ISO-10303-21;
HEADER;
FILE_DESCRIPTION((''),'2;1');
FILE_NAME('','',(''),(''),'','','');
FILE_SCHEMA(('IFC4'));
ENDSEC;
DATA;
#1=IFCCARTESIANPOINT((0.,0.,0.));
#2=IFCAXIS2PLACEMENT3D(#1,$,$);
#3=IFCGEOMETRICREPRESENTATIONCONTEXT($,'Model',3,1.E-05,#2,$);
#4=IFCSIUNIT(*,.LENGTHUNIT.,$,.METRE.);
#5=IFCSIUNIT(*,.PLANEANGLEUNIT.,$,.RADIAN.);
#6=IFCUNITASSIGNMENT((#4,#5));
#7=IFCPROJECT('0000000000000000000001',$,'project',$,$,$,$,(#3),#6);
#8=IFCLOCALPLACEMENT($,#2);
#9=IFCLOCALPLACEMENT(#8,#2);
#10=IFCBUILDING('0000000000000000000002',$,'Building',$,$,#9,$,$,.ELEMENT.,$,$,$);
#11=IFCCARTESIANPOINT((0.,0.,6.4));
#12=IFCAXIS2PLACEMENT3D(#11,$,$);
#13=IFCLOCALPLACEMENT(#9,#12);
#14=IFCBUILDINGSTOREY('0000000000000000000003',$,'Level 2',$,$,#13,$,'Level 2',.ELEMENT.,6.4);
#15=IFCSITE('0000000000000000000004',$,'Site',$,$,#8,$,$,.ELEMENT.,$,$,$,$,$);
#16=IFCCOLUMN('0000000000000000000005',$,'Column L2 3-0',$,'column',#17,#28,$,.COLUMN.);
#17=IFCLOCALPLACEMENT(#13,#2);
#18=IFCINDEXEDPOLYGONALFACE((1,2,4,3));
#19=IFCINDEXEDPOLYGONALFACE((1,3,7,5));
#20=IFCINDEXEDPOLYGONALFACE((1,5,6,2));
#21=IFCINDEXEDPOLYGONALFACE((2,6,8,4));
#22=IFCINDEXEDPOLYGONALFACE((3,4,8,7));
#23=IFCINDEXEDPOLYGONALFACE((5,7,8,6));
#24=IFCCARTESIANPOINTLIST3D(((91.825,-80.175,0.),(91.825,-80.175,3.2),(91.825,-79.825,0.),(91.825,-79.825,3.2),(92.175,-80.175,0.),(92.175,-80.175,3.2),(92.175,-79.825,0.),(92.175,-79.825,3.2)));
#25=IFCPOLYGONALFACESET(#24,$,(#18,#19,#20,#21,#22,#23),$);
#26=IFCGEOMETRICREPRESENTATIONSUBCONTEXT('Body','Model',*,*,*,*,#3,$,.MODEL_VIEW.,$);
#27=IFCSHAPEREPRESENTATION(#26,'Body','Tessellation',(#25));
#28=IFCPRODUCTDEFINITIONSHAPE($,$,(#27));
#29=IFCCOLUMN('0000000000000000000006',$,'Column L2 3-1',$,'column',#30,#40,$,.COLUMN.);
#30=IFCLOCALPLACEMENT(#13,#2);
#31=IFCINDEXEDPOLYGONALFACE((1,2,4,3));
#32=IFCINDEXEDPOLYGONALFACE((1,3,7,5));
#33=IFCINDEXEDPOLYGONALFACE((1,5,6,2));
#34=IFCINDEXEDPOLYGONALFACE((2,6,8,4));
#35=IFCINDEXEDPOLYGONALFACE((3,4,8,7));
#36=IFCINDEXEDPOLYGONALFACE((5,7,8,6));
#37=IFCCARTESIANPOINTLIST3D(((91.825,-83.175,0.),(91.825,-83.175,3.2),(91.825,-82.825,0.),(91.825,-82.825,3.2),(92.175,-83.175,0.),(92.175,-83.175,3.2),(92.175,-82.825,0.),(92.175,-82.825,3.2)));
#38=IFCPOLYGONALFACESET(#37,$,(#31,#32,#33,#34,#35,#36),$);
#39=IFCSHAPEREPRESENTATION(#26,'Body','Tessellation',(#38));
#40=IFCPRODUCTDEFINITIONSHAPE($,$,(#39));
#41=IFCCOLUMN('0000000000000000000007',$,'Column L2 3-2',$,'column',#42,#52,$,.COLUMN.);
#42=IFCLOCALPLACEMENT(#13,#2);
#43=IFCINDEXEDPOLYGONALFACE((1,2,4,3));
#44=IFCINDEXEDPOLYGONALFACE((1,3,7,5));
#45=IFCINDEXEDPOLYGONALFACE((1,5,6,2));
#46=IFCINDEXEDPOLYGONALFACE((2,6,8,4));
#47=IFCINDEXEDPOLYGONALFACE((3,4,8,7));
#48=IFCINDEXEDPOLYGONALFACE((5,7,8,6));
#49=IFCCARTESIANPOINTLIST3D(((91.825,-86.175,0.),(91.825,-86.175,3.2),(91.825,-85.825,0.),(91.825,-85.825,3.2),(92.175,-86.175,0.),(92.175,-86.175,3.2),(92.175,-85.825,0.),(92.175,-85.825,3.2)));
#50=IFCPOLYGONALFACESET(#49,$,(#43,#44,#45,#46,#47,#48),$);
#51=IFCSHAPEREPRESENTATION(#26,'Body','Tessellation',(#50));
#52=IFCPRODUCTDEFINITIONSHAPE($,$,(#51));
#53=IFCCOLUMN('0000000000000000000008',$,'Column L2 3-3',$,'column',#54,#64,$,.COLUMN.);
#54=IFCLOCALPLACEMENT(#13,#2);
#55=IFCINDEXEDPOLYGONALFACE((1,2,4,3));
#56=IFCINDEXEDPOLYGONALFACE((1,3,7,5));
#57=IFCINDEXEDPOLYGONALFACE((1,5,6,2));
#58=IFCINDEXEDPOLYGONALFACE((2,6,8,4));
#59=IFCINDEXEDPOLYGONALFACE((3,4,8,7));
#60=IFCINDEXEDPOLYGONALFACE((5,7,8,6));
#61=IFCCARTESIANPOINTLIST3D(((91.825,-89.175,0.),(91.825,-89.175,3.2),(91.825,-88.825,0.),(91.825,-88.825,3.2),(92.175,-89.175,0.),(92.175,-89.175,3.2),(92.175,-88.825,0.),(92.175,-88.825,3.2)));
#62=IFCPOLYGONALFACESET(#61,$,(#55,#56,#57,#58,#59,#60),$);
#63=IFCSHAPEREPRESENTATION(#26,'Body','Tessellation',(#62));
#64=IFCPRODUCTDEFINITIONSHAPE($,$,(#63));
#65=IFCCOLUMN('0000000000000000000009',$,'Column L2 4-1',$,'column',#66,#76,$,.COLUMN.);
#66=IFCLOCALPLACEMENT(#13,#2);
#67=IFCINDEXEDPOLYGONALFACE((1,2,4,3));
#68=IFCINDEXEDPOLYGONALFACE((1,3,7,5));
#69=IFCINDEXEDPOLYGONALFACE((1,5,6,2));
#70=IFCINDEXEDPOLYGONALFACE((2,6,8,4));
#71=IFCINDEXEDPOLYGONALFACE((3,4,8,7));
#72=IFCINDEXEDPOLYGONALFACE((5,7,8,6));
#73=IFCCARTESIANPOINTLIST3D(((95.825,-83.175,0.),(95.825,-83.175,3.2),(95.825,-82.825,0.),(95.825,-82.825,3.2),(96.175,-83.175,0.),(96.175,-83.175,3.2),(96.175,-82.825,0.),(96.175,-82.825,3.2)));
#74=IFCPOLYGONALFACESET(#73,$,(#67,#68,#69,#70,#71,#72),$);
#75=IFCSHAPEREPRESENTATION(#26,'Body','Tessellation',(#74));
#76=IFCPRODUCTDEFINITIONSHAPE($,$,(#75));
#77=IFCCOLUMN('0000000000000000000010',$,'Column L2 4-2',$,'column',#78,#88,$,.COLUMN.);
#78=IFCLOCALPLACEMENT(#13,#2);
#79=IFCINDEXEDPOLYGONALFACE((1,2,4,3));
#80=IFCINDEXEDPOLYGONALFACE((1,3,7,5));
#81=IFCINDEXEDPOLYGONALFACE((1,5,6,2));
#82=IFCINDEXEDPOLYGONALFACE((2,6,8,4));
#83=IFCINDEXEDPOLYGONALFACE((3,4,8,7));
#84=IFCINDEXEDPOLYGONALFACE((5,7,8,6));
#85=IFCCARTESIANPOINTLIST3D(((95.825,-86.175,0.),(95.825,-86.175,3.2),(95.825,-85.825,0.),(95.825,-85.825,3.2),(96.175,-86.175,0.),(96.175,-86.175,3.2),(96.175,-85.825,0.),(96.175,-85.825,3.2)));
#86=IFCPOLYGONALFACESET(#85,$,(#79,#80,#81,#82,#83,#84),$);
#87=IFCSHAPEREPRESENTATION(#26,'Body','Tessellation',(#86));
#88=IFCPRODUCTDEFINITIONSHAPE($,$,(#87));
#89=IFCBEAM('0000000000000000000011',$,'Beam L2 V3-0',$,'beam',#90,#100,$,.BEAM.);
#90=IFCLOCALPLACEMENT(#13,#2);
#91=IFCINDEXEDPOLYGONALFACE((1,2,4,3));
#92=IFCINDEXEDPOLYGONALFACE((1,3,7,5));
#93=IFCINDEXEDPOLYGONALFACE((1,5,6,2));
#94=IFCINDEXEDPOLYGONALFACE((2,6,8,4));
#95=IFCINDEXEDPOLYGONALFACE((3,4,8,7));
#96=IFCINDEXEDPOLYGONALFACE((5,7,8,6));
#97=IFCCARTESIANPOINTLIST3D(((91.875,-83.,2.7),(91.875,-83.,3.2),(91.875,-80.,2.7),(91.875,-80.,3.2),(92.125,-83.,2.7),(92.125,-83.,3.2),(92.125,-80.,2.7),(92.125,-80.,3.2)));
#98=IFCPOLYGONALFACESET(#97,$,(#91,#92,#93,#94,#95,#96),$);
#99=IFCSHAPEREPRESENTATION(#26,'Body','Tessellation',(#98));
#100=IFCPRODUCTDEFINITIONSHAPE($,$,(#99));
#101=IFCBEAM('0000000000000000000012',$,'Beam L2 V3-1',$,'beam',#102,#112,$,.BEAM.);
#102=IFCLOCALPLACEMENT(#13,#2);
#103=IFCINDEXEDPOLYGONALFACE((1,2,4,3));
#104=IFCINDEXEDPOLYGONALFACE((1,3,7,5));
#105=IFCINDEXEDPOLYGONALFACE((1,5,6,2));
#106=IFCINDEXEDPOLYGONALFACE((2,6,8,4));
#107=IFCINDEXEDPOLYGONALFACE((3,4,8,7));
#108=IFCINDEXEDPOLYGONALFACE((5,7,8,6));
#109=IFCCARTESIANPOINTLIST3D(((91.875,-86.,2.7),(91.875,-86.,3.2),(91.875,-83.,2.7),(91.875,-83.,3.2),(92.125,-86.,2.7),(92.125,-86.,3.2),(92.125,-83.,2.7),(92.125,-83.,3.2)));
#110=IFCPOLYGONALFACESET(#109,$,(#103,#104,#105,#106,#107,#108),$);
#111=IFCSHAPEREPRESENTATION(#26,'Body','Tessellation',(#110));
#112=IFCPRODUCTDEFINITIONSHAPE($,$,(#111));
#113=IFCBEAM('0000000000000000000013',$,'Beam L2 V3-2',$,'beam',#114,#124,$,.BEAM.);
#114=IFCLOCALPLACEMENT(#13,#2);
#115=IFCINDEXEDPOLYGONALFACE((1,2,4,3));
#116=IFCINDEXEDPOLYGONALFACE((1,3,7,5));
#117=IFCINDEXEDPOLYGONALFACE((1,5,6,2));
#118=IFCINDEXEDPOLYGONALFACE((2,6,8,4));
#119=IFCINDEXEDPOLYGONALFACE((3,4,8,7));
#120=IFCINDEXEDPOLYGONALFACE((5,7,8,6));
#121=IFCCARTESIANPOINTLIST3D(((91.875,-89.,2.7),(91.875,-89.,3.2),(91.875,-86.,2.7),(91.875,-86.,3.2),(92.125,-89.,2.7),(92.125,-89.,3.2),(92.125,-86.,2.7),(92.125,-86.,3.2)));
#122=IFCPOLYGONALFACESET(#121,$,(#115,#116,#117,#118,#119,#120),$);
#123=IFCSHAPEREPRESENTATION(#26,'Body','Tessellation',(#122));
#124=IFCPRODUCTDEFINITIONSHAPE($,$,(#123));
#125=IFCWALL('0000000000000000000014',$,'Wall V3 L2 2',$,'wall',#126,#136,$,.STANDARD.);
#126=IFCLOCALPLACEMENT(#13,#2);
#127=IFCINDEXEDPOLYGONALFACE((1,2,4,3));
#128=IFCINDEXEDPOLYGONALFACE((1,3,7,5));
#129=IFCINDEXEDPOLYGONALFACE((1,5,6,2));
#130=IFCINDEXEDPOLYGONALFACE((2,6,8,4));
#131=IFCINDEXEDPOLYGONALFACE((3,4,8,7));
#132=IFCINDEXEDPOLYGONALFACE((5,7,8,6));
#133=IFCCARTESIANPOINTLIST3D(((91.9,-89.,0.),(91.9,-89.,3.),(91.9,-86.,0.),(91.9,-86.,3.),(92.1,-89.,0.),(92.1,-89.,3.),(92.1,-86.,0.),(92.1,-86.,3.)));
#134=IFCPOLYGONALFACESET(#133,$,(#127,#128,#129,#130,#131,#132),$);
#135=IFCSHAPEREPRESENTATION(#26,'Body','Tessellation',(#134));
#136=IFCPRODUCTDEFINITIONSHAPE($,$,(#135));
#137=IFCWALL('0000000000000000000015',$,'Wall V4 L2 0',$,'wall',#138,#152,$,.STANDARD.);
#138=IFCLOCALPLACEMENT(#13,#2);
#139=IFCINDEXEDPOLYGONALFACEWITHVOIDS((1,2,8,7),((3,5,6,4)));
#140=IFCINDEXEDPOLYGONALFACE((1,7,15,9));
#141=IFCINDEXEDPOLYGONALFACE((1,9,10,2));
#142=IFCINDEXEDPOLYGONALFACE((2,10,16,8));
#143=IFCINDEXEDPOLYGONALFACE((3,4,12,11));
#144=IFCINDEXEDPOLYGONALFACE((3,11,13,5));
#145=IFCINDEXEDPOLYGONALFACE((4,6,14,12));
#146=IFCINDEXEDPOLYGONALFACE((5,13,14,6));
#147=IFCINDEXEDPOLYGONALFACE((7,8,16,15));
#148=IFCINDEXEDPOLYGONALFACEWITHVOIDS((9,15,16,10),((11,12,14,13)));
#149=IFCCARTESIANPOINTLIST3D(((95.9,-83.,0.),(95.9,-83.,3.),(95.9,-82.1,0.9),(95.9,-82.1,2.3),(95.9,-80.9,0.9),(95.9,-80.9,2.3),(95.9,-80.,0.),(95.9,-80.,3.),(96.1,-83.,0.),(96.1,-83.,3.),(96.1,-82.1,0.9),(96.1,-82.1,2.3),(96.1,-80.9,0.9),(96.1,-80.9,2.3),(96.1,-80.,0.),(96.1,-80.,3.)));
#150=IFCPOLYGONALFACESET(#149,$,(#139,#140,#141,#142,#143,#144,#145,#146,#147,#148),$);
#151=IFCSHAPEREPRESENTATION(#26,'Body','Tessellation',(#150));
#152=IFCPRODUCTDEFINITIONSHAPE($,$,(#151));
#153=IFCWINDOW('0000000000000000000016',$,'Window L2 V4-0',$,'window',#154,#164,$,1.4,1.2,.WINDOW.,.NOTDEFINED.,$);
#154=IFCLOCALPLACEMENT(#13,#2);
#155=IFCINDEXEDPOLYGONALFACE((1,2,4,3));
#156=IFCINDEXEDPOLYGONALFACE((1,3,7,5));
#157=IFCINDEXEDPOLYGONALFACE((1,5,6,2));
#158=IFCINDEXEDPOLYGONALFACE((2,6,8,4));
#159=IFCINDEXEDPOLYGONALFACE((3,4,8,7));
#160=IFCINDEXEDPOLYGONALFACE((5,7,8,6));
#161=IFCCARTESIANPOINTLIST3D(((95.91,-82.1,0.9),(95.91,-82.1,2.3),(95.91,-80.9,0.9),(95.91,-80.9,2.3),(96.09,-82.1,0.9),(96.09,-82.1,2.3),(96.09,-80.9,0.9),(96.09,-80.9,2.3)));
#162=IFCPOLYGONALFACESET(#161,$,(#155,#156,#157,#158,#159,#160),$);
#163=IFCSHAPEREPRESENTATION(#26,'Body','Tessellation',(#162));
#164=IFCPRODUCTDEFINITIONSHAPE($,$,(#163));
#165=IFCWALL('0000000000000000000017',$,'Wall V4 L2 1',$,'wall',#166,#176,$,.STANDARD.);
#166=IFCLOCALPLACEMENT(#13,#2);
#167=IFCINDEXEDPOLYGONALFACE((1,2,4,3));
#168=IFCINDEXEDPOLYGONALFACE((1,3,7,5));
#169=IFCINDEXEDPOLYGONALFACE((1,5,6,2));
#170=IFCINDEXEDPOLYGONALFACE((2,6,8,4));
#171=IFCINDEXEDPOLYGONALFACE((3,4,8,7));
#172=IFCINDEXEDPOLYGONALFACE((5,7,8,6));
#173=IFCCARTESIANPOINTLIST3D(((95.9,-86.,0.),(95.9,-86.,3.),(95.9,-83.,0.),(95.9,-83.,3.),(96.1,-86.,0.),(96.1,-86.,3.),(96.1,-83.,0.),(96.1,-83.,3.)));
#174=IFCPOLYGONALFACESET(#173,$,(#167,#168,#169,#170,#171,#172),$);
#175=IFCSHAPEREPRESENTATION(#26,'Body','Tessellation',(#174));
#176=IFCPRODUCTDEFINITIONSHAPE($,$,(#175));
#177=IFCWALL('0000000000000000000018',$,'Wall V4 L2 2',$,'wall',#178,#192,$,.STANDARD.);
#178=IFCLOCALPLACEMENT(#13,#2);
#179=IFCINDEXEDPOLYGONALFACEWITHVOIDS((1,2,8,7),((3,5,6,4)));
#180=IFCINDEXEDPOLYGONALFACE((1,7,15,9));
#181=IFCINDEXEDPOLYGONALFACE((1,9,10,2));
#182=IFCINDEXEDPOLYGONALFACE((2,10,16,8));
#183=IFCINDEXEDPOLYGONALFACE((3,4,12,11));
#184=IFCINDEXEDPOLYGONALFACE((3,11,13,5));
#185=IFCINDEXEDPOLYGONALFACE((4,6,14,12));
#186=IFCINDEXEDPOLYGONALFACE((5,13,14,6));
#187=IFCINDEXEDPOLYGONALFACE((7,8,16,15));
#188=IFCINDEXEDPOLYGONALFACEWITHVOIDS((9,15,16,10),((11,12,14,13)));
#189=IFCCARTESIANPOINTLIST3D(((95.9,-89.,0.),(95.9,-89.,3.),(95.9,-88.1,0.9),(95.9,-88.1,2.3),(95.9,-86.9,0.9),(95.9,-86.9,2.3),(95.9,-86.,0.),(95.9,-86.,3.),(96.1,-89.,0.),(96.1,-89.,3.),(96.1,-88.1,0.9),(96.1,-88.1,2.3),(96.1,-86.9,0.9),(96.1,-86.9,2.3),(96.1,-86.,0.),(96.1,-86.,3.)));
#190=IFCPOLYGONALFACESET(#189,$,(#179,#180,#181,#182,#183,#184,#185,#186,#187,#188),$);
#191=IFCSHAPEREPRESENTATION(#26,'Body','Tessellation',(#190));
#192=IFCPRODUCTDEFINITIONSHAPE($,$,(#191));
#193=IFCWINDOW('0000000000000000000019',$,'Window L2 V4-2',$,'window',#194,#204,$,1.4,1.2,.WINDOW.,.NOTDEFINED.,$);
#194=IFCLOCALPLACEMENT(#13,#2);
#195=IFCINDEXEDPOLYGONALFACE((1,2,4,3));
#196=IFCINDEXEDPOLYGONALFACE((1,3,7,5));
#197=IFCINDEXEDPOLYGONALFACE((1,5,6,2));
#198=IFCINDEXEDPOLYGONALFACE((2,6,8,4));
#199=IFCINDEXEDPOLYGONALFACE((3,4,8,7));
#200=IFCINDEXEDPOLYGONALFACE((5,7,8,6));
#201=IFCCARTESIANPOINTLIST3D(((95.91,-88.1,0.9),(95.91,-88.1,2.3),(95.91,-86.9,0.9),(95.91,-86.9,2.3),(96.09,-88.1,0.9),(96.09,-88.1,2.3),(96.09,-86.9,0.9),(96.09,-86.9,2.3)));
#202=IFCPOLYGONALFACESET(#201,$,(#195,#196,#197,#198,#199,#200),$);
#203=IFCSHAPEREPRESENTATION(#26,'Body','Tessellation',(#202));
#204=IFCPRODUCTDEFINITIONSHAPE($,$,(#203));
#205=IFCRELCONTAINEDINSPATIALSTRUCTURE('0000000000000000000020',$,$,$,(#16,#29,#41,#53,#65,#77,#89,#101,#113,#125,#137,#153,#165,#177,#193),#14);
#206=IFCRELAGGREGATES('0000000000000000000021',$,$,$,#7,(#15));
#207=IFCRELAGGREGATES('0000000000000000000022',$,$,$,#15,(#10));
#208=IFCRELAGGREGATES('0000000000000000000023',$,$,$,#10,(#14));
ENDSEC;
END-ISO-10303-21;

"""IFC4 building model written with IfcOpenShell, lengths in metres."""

from ifc_helpers import new_model, si_unit, frame, frame_2d, origin, origin_2d, place, context, subcontext, project, spatial, rectangle, extrude, element, fill, save


model = new_model("IFC4")

# Units and contexts
model_context = context("Model", 3, precision=1e-05, world=origin())
body_context = subcontext(model_context, "Body", "Model", "MODEL_VIEW")
ifc_project = project(units=[si_unit("LENGTHUNIT", "METRE"), si_unit("PLANEANGLEUNIT", "RADIAN")], contexts=[model_context])

# Site, building, storey
site_placement = place(None, origin())
site = spatial("IfcSite", under=ifc_project, at=site_placement, Name="Site", CompositionType="ELEMENT")
building_placement = place(site_placement, origin())
building = spatial("IfcBuilding", under=site, at=building_placement, Name="Building", CompositionType="ELEMENT")
storey_placement = place(building_placement, frame((0.0, 0.0, 6.4)))
storey = spatial("IfcBuildingStorey", under=building, at=storey_placement, Name="Level 2", LongName="Level 2", CompositionType="ELEMENT", Elevation=6.4)

# Columns
for number, where, name in (
    (1, (92.0, -80.0, 0.0), "Column L2 3-0"),
    (2, (92.0, -83.0, 0.0), "Column L2 3-1"),
    (3, (92.0, -86.0, 0.0), "Column L2 3-2"),
    (4, (92.0, -89.0, 0.0), "Column L2 3-3"),
    (5, (96.0, -83.0, 0.0), "Column L2 4-1"),
    (6, (96.0, -86.0, 0.0), "Column L2 4-2"),
):
    element("IfcColumn", number, at=place(storey_placement, frame(where)), inside=storey, Name=name, ObjectType="column", PredefinedType="COLUMN", context=body_context, shape_type="SweptSolid", body=[
        extrude(rectangle(XDim=0.35, YDim=0.35, at=origin_2d()), origin(), (0.0, 0.0, 1.0), 3.2),
    ])

# Beams
for number, where, z_axis, x_axis, name in (
    (7, (92.0, -80.0, 2.95), (0.0, -1.0, 0.0), (0.0, 0.0, 1.0), "Beam L2 V3-0"),
    (8, (92.0, -83.0, 2.95), (0.0, -1.0, 0.0), (0.0, 0.0, 1.0), "Beam L2 V3-1"),
    (9, (92.0, -86.0, 2.95), (0.0, -1.0, 0.0), (0.0, 0.0, 1.0), "Beam L2 V3-2"),
):
    element("IfcBeam", number, at=place(storey_placement, frame(where, z_axis=z_axis, x_axis=x_axis)), inside=storey, Name=name, ObjectType="beam", PredefinedType="BEAM", context=body_context, shape_type="SweptSolid", body=[
        extrude(rectangle(XDim=0.5, YDim=0.25, at=origin_2d()), origin(), (0.0, 0.0, 1.0), 3.0),
    ])

# Wall
wall_1_placement = place(storey_placement, frame((92.0, -86.0, 0.0), z_axis=(0.0, 0.0, 1.0), x_axis=(0.0, -1.0, 0.0)))
element("IfcWall", 10, at=wall_1_placement, inside=storey, Name="Wall V3 L2 2", ObjectType="wall", PredefinedType="STANDARD", context=body_context, shape_type="SweptSolid", body=[
    extrude(rectangle(XDim=3.0, YDim=0.2, at=frame_2d((1.5, 0.0))), origin(), (0.0, 0.0, 1.0), 3.0),
])

# Wall, opening, window
wall_2_placement = place(storey_placement, frame((96.0, -80.0, 0.0), z_axis=(0.0, 0.0, 1.0), x_axis=(0.0, -1.0, 0.0)))
wall_2 = element("IfcWall", 11, at=wall_2_placement, inside=storey, Name="Wall V4 L2 0", ObjectType="wall", PredefinedType="STANDARD", context=body_context, shape_type="SweptSolid", body=[
    extrude(rectangle(XDim=3.0, YDim=0.2, at=frame_2d((1.5, 0.0))), origin(), (0.0, 0.0, 1.0), 3.0),
])
opening_1_placement = place(storey_placement, frame((96.0, -81.5, 0.9), z_axis=(0.0, 0.0, 1.0), x_axis=(0.0, -1.0, 0.0)))
opening_1 = element("IfcOpeningElement", 12, at=opening_1_placement, cuts=wall_2, ObjectType="Opening", PredefinedType="OPENING", context=body_context, shape_type="SweptSolid", body=[
    extrude(rectangle(XDim=1.2, YDim=0.22, at=origin_2d()), origin(), (0.0, 0.0, 1.0), 1.4),
])
window_1_placement = place(storey_placement, frame((96.0, -81.5, 0.9), z_axis=(0.0, 0.0, 1.0), x_axis=(0.0, -1.0, 0.0)))
window_1 = element("IfcWindow", 13, at=window_1_placement, inside=storey, Name="Window L2 V4-0", ObjectType="window", OverallHeight=1.4, OverallWidth=1.2, PartitioningType="NOTDEFINED", PredefinedType="WINDOW", context=body_context, shape_type="SweptSolid", body=[
    extrude(rectangle(XDim=1.2, YDim=0.18, at=origin_2d()), origin(), (0.0, 0.0, 1.0), 1.4),
])
fill(opening_1, window_1)

# Wall
wall_3_placement = place(storey_placement, frame((96.0, -83.0, 0.0), z_axis=(0.0, 0.0, 1.0), x_axis=(0.0, -1.0, 0.0)))
element("IfcWall", 14, at=wall_3_placement, inside=storey, Name="Wall V4 L2 1", ObjectType="wall", PredefinedType="STANDARD", context=body_context, shape_type="SweptSolid", body=[
    extrude(rectangle(XDim=3.0, YDim=0.2, at=frame_2d((1.5, 0.0))), origin(), (0.0, 0.0, 1.0), 3.0),
])

# Wall, opening, window
wall_4_placement = place(storey_placement, frame((96.0, -86.0, 0.0), z_axis=(0.0, 0.0, 1.0), x_axis=(0.0, -1.0, 0.0)))
wall_4 = element("IfcWall", 15, at=wall_4_placement, inside=storey, Name="Wall V4 L2 2", ObjectType="wall", PredefinedType="STANDARD", context=body_context, shape_type="SweptSolid", body=[
    extrude(rectangle(XDim=3.0, YDim=0.2, at=frame_2d((1.5, 0.0))), origin(), (0.0, 0.0, 1.0), 3.0),
])
opening_2_placement = place(storey_placement, frame((96.0, -87.5, 0.9), z_axis=(0.0, 0.0, 1.0), x_axis=(0.0, -1.0, 0.0)))
opening_2 = element("IfcOpeningElement", 16, at=opening_2_placement, cuts=wall_4, ObjectType="Opening", PredefinedType="OPENING", context=body_context, shape_type="SweptSolid", body=[
    extrude(rectangle(XDim=1.2, YDim=0.22, at=origin_2d()), origin(), (0.0, 0.0, 1.0), 1.4),
])
window_2_placement = place(storey_placement, frame((96.0, -87.5, 0.9), z_axis=(0.0, 0.0, 1.0), x_axis=(0.0, -1.0, 0.0)))
window_2 = element("IfcWindow", 17, at=window_2_placement, inside=storey, Name="Window L2 V4-2", ObjectType="window", OverallHeight=1.4, OverallWidth=1.2, PartitioningType="NOTDEFINED", PredefinedType="WINDOW", context=body_context, shape_type="SweptSolid", body=[
    extrude(rectangle(XDim=1.2, YDim=0.18, at=origin_2d()), origin(), (0.0, 0.0, 1.0), 1.4),
])
fill(opening_2, window_2)

save(model, "model.ifc")
